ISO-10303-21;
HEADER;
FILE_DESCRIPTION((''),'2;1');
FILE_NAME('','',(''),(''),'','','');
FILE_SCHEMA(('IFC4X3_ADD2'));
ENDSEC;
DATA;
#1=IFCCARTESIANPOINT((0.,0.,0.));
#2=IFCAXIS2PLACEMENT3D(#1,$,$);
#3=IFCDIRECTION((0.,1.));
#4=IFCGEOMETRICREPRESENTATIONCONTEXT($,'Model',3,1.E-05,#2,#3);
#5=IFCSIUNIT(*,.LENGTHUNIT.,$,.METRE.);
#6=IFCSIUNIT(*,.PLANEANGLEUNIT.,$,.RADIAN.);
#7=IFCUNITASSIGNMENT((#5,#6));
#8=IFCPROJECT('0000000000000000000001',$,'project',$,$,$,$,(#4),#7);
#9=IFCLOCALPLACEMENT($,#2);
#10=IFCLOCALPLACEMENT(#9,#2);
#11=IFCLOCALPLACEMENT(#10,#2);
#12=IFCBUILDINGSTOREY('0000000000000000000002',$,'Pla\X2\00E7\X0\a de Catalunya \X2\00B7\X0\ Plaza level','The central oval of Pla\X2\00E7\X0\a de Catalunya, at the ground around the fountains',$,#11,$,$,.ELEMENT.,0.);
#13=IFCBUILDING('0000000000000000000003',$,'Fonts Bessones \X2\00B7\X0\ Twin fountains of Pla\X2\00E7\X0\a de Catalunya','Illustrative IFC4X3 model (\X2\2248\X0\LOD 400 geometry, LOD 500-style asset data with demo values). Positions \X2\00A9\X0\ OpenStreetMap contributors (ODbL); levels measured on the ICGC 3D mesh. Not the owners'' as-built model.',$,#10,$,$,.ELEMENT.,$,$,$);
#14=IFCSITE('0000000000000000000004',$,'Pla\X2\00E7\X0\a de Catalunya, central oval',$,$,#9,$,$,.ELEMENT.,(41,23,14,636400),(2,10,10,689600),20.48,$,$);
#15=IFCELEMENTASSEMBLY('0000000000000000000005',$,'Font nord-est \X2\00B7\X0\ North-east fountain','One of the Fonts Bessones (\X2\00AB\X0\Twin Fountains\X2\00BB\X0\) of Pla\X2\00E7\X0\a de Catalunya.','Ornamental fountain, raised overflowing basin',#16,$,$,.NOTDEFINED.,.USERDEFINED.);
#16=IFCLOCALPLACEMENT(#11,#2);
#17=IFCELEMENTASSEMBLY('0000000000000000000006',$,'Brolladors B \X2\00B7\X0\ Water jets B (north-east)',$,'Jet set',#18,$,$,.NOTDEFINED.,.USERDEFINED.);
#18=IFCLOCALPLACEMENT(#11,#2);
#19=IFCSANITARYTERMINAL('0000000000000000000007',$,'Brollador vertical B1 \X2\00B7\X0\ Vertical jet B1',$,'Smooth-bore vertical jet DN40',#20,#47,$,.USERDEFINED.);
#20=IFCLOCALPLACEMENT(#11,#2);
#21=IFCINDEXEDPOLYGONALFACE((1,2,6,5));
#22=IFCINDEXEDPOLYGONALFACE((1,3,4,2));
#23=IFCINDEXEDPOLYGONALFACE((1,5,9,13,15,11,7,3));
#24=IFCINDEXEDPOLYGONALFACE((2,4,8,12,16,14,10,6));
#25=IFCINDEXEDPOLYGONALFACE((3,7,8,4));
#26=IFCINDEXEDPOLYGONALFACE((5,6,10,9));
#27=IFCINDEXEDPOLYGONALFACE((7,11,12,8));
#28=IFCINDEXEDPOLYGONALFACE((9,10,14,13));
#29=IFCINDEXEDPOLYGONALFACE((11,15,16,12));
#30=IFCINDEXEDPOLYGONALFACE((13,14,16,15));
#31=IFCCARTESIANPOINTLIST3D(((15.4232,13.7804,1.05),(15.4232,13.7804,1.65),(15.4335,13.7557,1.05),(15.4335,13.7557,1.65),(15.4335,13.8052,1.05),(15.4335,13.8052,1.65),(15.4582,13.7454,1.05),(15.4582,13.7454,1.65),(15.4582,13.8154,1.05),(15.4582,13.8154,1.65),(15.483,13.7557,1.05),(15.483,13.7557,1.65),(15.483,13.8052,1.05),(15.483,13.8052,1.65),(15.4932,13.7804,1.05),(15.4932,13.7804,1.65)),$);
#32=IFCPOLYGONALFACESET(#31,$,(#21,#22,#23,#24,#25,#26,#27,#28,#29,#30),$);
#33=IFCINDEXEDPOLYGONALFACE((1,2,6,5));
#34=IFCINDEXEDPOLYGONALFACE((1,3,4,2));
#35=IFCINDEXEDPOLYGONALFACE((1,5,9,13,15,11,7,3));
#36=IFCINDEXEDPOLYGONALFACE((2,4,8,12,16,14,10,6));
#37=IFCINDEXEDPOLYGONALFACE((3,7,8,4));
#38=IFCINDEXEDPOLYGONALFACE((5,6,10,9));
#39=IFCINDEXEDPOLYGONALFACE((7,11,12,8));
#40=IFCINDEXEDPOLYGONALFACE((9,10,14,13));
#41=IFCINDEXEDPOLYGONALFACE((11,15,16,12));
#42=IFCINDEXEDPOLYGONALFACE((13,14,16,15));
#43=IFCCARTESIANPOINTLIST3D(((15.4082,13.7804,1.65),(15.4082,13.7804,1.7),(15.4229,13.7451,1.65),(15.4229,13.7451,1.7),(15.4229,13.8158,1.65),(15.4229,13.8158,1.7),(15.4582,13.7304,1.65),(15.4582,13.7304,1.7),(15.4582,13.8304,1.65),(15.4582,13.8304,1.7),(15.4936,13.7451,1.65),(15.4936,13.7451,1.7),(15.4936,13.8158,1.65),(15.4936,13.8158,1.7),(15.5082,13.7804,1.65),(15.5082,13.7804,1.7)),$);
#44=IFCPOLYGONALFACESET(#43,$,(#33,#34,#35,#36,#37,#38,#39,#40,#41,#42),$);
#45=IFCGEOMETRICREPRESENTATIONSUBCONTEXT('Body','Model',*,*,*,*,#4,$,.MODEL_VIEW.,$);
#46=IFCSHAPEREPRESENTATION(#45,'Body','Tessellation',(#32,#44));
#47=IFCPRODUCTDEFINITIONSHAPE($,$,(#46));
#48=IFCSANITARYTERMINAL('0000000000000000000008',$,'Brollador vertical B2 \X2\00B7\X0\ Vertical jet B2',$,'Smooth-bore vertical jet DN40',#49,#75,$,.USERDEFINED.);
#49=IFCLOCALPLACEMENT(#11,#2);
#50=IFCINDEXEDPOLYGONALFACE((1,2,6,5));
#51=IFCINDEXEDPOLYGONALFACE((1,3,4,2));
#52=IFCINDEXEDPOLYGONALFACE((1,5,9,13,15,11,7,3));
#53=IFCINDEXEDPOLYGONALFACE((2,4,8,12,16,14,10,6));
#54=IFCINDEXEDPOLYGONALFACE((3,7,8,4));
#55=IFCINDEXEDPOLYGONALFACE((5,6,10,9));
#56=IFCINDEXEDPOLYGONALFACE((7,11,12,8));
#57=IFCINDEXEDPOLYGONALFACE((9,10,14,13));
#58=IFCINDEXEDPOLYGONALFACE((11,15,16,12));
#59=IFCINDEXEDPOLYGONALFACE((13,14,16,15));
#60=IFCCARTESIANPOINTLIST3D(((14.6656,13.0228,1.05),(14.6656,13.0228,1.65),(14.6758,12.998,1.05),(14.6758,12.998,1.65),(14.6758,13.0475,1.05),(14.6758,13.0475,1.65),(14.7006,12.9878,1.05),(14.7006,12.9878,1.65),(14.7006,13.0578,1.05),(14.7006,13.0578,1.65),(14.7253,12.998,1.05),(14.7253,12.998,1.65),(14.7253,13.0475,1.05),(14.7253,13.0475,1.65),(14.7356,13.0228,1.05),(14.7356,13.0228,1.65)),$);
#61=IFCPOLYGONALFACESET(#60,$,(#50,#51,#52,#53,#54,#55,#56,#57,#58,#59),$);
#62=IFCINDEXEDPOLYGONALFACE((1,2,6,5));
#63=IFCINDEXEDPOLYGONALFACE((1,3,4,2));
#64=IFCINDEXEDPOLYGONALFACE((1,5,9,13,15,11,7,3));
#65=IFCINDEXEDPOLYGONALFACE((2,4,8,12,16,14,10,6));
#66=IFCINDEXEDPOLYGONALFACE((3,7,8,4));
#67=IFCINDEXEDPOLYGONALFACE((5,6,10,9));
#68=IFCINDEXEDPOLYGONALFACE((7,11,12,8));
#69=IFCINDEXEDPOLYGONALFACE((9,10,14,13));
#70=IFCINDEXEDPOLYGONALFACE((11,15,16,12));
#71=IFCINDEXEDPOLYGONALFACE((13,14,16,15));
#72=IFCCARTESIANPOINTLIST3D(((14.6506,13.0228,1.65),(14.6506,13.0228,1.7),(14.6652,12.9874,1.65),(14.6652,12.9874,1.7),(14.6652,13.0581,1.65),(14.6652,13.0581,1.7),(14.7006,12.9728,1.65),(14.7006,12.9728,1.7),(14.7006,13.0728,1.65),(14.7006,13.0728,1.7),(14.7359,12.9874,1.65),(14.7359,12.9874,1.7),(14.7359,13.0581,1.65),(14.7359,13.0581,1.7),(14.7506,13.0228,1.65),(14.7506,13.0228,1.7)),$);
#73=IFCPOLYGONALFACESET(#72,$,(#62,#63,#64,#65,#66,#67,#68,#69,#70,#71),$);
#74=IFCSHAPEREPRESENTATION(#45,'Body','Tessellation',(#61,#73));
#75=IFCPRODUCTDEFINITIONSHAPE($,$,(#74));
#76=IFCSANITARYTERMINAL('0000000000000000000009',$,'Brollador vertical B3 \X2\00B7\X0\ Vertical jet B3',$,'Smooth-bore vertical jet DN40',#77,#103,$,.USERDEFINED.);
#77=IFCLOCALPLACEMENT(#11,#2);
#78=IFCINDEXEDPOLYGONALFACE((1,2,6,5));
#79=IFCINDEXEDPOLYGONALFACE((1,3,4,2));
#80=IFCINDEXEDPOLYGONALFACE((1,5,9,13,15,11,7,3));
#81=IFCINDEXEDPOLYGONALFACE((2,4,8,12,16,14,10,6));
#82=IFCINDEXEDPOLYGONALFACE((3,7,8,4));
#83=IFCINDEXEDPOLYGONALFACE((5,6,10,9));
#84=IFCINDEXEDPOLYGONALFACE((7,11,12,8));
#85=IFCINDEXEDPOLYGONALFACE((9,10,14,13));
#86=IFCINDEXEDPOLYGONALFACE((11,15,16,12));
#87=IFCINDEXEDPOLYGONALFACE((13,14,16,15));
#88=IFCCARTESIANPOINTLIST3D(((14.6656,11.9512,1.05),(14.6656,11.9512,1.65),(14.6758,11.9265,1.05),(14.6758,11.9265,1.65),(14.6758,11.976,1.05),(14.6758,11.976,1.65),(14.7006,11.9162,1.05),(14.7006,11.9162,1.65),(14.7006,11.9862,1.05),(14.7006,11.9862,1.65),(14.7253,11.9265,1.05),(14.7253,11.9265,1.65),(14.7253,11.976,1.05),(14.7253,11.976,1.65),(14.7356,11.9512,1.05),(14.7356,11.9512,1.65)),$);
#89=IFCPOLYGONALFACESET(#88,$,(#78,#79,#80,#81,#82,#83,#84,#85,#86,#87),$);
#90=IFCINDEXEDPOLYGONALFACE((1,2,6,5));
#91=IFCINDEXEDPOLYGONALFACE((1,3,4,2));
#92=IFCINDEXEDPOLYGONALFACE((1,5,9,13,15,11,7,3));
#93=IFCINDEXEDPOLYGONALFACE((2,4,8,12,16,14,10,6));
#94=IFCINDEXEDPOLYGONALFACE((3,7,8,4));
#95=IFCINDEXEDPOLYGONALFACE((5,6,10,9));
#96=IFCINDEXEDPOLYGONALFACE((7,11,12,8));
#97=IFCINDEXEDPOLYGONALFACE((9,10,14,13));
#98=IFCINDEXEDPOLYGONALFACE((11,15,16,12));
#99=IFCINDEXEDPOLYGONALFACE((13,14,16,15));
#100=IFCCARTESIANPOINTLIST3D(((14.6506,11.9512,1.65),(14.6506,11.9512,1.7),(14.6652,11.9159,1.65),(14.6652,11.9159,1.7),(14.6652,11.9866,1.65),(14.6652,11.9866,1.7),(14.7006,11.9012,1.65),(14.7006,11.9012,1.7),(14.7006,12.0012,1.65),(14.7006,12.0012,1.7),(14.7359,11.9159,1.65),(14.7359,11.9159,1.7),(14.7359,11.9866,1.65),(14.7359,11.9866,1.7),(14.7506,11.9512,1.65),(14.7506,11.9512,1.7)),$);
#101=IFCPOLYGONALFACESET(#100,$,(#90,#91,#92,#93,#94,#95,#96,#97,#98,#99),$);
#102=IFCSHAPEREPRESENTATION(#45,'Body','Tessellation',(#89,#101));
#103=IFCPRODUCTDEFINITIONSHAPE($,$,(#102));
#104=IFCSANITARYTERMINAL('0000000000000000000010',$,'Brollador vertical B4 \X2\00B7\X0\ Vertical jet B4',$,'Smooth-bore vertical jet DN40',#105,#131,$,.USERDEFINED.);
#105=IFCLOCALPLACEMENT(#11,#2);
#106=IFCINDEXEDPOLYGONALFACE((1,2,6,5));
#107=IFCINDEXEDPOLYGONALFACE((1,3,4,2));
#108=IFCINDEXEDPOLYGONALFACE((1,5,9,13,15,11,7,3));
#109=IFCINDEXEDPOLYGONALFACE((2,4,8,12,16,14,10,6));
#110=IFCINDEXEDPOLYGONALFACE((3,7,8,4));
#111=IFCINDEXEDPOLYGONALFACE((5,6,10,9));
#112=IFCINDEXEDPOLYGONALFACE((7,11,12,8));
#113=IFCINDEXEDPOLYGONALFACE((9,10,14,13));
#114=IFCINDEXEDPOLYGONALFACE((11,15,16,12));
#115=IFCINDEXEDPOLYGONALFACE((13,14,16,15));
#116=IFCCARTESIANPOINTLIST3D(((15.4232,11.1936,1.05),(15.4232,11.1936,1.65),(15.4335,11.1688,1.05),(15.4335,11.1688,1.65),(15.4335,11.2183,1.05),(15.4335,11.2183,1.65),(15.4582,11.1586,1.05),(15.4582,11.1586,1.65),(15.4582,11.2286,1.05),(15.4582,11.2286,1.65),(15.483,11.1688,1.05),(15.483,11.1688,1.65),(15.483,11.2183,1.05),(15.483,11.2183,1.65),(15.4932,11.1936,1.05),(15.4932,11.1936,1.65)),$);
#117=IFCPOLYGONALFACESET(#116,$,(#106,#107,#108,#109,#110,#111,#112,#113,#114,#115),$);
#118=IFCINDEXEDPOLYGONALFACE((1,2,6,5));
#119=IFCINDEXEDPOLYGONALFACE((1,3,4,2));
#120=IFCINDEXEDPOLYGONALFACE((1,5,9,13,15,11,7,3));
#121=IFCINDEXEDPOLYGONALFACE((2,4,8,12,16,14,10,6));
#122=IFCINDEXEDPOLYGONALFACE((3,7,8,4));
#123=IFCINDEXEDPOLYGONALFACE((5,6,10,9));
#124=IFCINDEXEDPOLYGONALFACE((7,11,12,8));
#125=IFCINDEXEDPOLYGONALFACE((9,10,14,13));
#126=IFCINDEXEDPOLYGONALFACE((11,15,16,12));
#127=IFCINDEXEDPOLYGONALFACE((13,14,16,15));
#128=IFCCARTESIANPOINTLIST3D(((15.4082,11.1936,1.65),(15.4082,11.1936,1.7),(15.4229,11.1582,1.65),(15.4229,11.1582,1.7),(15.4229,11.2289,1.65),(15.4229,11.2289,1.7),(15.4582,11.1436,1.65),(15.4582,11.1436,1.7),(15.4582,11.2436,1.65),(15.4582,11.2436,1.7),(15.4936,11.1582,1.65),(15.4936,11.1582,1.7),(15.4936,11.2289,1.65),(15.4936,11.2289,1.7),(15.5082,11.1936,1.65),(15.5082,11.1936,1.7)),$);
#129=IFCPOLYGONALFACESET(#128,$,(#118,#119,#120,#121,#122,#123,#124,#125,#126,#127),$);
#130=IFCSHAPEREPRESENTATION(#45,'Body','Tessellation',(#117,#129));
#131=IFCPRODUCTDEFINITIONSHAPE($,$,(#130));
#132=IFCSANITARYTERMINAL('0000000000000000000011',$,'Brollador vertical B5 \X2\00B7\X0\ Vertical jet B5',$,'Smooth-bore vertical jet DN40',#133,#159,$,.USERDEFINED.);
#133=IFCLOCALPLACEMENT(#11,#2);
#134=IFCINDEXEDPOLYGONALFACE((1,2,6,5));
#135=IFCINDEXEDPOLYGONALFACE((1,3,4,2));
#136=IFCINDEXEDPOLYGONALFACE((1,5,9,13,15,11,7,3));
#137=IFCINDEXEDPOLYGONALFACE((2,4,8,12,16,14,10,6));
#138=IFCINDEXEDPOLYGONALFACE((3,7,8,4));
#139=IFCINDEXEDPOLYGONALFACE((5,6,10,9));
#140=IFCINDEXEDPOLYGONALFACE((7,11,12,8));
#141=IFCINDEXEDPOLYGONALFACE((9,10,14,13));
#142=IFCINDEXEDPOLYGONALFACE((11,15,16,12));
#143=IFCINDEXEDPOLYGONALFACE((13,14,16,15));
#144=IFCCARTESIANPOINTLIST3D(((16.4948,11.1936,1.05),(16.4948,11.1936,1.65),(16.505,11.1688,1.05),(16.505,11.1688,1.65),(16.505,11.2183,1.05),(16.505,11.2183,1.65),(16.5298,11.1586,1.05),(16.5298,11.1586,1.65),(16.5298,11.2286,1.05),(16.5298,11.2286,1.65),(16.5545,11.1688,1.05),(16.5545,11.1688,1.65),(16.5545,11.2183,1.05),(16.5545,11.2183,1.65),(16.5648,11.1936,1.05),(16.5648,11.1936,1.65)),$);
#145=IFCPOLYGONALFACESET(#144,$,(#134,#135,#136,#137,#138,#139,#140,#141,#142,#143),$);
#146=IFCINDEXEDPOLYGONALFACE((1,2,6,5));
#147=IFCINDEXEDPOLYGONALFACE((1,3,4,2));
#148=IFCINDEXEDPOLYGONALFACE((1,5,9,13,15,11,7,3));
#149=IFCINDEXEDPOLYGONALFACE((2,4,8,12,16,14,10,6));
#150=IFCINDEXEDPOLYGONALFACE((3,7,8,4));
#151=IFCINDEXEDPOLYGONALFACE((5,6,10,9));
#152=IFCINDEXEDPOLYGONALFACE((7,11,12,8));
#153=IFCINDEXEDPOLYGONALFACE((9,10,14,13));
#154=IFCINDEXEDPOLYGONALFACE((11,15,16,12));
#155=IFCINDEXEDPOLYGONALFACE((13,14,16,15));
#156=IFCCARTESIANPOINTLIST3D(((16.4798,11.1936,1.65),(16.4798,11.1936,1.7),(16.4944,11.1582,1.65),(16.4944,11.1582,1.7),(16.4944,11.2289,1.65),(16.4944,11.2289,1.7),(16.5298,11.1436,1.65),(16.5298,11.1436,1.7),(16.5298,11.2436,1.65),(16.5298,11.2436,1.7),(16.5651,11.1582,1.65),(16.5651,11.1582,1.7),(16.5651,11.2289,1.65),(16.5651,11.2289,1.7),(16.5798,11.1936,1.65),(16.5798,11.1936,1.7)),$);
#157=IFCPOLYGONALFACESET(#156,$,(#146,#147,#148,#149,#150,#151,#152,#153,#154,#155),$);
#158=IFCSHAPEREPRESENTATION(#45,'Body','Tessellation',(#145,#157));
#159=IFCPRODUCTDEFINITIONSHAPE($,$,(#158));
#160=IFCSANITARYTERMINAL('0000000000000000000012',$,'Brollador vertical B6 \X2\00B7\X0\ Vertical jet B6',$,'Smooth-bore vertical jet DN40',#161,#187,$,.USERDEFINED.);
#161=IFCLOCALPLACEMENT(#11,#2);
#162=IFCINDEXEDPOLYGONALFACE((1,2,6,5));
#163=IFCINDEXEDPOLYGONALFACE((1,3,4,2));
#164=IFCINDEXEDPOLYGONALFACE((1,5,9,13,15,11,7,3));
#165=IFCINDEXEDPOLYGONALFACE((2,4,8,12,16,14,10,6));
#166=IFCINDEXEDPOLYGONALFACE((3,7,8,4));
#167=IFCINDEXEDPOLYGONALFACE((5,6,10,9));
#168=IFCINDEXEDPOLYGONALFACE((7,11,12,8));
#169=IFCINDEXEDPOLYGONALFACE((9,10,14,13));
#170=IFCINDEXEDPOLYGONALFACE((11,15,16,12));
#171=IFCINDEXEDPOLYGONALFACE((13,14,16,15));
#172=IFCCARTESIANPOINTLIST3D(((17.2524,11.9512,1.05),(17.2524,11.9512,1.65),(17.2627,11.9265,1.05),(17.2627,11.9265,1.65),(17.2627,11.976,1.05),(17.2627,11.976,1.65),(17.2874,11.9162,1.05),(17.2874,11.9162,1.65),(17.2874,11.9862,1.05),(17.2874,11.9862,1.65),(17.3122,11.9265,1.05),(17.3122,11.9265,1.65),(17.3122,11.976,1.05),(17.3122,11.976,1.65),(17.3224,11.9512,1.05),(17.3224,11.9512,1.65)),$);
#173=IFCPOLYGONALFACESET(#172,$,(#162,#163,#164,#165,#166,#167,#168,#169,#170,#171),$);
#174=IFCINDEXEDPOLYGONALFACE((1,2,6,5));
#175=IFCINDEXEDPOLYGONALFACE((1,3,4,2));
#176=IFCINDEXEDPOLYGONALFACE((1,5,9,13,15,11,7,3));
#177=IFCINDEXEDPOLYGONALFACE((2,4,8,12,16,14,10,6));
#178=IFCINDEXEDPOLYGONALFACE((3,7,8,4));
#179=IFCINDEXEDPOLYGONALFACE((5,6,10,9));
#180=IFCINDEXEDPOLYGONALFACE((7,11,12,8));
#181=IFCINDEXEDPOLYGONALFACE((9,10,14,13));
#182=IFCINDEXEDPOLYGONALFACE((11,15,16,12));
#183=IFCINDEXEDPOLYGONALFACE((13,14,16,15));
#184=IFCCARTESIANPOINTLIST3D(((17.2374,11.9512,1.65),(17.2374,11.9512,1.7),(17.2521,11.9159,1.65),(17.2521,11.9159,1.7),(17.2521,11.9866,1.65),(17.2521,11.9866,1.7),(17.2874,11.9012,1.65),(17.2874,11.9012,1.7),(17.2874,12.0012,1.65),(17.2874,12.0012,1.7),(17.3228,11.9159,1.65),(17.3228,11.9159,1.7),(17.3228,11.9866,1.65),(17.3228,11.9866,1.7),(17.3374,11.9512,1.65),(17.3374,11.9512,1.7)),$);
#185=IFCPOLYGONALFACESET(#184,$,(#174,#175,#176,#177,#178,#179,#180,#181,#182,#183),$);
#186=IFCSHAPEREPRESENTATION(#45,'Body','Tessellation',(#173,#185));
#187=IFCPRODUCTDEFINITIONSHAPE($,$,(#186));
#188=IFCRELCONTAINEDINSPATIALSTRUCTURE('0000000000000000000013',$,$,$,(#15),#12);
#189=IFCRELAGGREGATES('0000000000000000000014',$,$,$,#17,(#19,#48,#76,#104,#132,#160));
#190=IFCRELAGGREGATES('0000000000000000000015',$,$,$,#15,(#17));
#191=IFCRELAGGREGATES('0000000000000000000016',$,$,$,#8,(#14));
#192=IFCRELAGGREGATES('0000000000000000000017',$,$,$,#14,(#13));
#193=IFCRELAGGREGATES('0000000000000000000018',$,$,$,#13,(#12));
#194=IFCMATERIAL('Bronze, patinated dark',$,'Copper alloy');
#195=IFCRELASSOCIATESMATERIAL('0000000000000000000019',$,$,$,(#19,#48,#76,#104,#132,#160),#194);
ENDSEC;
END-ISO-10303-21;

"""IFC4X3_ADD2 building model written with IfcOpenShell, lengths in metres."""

from ifc_helpers import new_model, si_unit, direction, frame, origin, place, context, subcontext, project, spatial, polyline, outline, extrude, material, element, aggregate, save


model = new_model("IFC4X3_ADD2")

# Units and contexts
model_context = context("Model", 3, precision=1e-05, world=origin(), true_north=direction((0.0, 1.0)))
body_context = subcontext(model_context, "Body", "Model", "MODEL_VIEW")
ifc_project = project(units=[si_unit("LENGTHUNIT", "METRE"), si_unit("PLANEANGLEUNIT", "RADIAN")], contexts=[model_context])

# Site, building, storey
site_placement = place(None, origin())
site = spatial("IfcSite", under=ifc_project, at=site_placement, Name="Plaça de Catalunya, central oval", CompositionType="ELEMENT", RefLatitude=(41, 23, 14, 636400), RefLongitude=(2, 10, 10, 689600), RefElevation=20.48)
building_placement = place(site_placement, origin())
building = spatial("IfcBuilding", under=site, at=building_placement, Name="Fonts Bessones · Twin fountains of Plaça de Catalunya", Description="Illustrative IFC4X3 model (≈LOD 400 geometry, LOD 500-style asset data with demo values). Positions © OpenStreetMap contributors (ODbL); levels measured on the ICGC 3D mesh. Not the owners' as-built model.", CompositionType="ELEMENT")
storey_placement = place(building_placement, origin())
storey = spatial("IfcBuildingStorey", under=building, at=storey_placement, Name="Plaça de Catalunya · Plaza level", Description="The central oval of Plaça de Catalunya, at the ground around the fountains", CompositionType="ELEMENT", Elevation=0.0)

# Element assemblies, sanitary terminals
assembly_1_placement = place(building_placement, origin())
assembly_1 = element("IfcElementAssembly", 1, at=assembly_1_placement, inside=storey, Name="Font nord-est · North-east fountain", Description="One of the Fonts Bessones («Twin Fountains») of Plaça de Catalunya.", ObjectType="Ornamental fountain, raised overflowing basin", AssemblyPlace="NOTDEFINED", PredefinedType="USERDEFINED")
assembly_2_placement = place(building_placement, origin())
assembly_2 = element("IfcElementAssembly", 2, at=assembly_2_placement, Name="Brolladors B · Water jets B (north-east)", ObjectType="Jet set", AssemblyPlace="NOTDEFINED", PredefinedType="USERDEFINED")
ifc_material_1 = material(Name="Bronze, patinated dark", Category="Copper alloy")
sanitary_terminal_1_placement = place(building_placement, origin())
sanitary_terminal_1 = element("IfcSanitaryTerminal", 3, at=sanitary_terminal_1_placement, material=ifc_material_1, Name="Brollador vertical B1 · Vertical jet B1", ObjectType="Smooth-bore vertical jet DN40", PredefinedType="USERDEFINED", context=body_context, shape_type="SweptSolid", body=[
    extrude(outline(polyline([(15.4932, 13.7804), (15.483, 13.8052), (15.4582, 13.8154), (15.4335, 13.8052), (15.4232, 13.7804), (15.4335, 13.7557), (15.4582, 13.7454), (15.483, 13.7557), (15.4932, 13.7804)])), frame((0.0, 0.0, 1.05)), (0.0, 0.0, 1.0), 0.6),
    extrude(outline(polyline([(15.5082, 13.7804), (15.4936, 13.8158), (15.4582, 13.8304), (15.4229, 13.8158), (15.4082, 13.7804), (15.4229, 13.7451), (15.4582, 13.7304), (15.4936, 13.7451), (15.5082, 13.7804)])), frame((0.0, 0.0, 1.65)), (0.0, 0.0, 1.0), 0.05),
])
sanitary_terminal_2_placement = place(building_placement, origin())
sanitary_terminal_2 = element("IfcSanitaryTerminal", 4, at=sanitary_terminal_2_placement, material=ifc_material_1, Name="Brollador vertical B2 · Vertical jet B2", ObjectType="Smooth-bore vertical jet DN40", PredefinedType="USERDEFINED", context=body_context, shape_type="SweptSolid", body=[
    extrude(outline(polyline([(14.7356, 13.0228), (14.7253, 13.0475), (14.7006, 13.0578), (14.6758, 13.0475), (14.6656, 13.0228), (14.6758, 12.998), (14.7006, 12.9878), (14.7253, 12.998), (14.7356, 13.0228)])), frame((0.0, 0.0, 1.05)), (0.0, 0.0, 1.0), 0.6),
    extrude(outline(polyline([(14.7506, 13.0228), (14.7359, 13.0581), (14.7006, 13.0728), (14.6652, 13.0581), (14.6506, 13.0228), (14.6652, 12.9874), (14.7006, 12.9728), (14.7359, 12.9874), (14.7506, 13.0228)])), frame((0.0, 0.0, 1.65)), (0.0, 0.0, 1.0), 0.05),
])
sanitary_terminal_3_placement = place(building_placement, origin())
sanitary_terminal_3 = element("IfcSanitaryTerminal", 5, at=sanitary_terminal_3_placement, material=ifc_material_1, Name="Brollador vertical B3 · Vertical jet B3", ObjectType="Smooth-bore vertical jet DN40", PredefinedType="USERDEFINED", context=body_context, shape_type="SweptSolid", body=[
    extrude(outline(polyline([(14.7356, 11.9512), (14.7253, 11.976), (14.7006, 11.9862), (14.6758, 11.976), (14.6656, 11.9512), (14.6758, 11.9265), (14.7006, 11.9162), (14.7253, 11.9265), (14.7356, 11.9512)])), frame((0.0, 0.0, 1.05)), (0.0, 0.0, 1.0), 0.6),
    extrude(outline(polyline([(14.7506, 11.9512), (14.7359, 11.9866), (14.7006, 12.0012), (14.6652, 11.9866), (14.6506, 11.9512), (14.6652, 11.9159), (14.7006, 11.9012), (14.7359, 11.9159), (14.7506, 11.9512)])), frame((0.0, 0.0, 1.65)), (0.0, 0.0, 1.0), 0.05),
])
sanitary_terminal_4_placement = place(building_placement, origin())
sanitary_terminal_4 = element("IfcSanitaryTerminal", 6, at=sanitary_terminal_4_placement, material=ifc_material_1, Name="Brollador vertical B4 · Vertical jet B4", ObjectType="Smooth-bore vertical jet DN40", PredefinedType="USERDEFINED", context=body_context, shape_type="SweptSolid", body=[
    extrude(outline(polyline([(15.4932, 11.1936), (15.483, 11.2183), (15.4582, 11.2286), (15.4335, 11.2183), (15.4232, 11.1936), (15.4335, 11.1688), (15.4582, 11.1586), (15.483, 11.1688), (15.4932, 11.1936)])), frame((0.0, 0.0, 1.05)), (0.0, 0.0, 1.0), 0.6),
    extrude(outline(polyline([(15.5082, 11.1936), (15.4936, 11.2289), (15.4582, 11.2436), (15.4229, 11.2289), (15.4082, 11.1936), (15.4229, 11.1582), (15.4582, 11.1436), (15.4936, 11.1582), (15.5082, 11.1936)])), frame((0.0, 0.0, 1.65)), (0.0, 0.0, 1.0), 0.05),
])
sanitary_terminal_5_placement = place(building_placement, origin())
sanitary_terminal_5 = element("IfcSanitaryTerminal", 7, at=sanitary_terminal_5_placement, material=ifc_material_1, Name="Brollador vertical B5 · Vertical jet B5", ObjectType="Smooth-bore vertical jet DN40", PredefinedType="USERDEFINED", context=body_context, shape_type="SweptSolid", body=[
    extrude(outline(polyline([(16.5648, 11.1936), (16.5545, 11.2183), (16.5298, 11.2286), (16.505, 11.2183), (16.4948, 11.1936), (16.505, 11.1688), (16.5298, 11.1586), (16.5545, 11.1688), (16.5648, 11.1936)])), frame((0.0, 0.0, 1.05)), (0.0, 0.0, 1.0), 0.6),
    extrude(outline(polyline([(16.5798, 11.1936), (16.5651, 11.2289), (16.5298, 11.2436), (16.4944, 11.2289), (16.4798, 11.1936), (16.4944, 11.1582), (16.5298, 11.1436), (16.5651, 11.1582), (16.5798, 11.1936)])), frame((0.0, 0.0, 1.65)), (0.0, 0.0, 1.0), 0.05),
])
sanitary_terminal_6_placement = place(building_placement, origin())
sanitary_terminal_6 = element("IfcSanitaryTerminal", 8, at=sanitary_terminal_6_placement, material=ifc_material_1, Name="Brollador vertical B6 · Vertical jet B6", ObjectType="Smooth-bore vertical jet DN40", PredefinedType="USERDEFINED", context=body_context, shape_type="SweptSolid", body=[
    extrude(outline(polyline([(17.3224, 11.9512), (17.3122, 11.976), (17.2874, 11.9862), (17.2627, 11.976), (17.2524, 11.9512), (17.2627, 11.9265), (17.2874, 11.9162), (17.3122, 11.9265), (17.3224, 11.9512)])), frame((0.0, 0.0, 1.05)), (0.0, 0.0, 1.0), 0.6),
    extrude(outline(polyline([(17.3374, 11.9512), (17.3228, 11.9866), (17.2874, 12.0012), (17.2521, 11.9866), (17.2374, 11.9512), (17.2521, 11.9159), (17.2874, 11.9012), (17.3228, 11.9159), (17.3374, 11.9512)])), frame((0.0, 0.0, 1.65)), (0.0, 0.0, 1.0), 0.05),
])
aggregate(assembly_2, [sanitary_terminal_1, sanitary_terminal_2, sanitary_terminal_3, sanitary_terminal_4, sanitary_terminal_5, sanitary_terminal_6])
aggregate(assembly_1, [assembly_2])

save(model, "model.ifc")
